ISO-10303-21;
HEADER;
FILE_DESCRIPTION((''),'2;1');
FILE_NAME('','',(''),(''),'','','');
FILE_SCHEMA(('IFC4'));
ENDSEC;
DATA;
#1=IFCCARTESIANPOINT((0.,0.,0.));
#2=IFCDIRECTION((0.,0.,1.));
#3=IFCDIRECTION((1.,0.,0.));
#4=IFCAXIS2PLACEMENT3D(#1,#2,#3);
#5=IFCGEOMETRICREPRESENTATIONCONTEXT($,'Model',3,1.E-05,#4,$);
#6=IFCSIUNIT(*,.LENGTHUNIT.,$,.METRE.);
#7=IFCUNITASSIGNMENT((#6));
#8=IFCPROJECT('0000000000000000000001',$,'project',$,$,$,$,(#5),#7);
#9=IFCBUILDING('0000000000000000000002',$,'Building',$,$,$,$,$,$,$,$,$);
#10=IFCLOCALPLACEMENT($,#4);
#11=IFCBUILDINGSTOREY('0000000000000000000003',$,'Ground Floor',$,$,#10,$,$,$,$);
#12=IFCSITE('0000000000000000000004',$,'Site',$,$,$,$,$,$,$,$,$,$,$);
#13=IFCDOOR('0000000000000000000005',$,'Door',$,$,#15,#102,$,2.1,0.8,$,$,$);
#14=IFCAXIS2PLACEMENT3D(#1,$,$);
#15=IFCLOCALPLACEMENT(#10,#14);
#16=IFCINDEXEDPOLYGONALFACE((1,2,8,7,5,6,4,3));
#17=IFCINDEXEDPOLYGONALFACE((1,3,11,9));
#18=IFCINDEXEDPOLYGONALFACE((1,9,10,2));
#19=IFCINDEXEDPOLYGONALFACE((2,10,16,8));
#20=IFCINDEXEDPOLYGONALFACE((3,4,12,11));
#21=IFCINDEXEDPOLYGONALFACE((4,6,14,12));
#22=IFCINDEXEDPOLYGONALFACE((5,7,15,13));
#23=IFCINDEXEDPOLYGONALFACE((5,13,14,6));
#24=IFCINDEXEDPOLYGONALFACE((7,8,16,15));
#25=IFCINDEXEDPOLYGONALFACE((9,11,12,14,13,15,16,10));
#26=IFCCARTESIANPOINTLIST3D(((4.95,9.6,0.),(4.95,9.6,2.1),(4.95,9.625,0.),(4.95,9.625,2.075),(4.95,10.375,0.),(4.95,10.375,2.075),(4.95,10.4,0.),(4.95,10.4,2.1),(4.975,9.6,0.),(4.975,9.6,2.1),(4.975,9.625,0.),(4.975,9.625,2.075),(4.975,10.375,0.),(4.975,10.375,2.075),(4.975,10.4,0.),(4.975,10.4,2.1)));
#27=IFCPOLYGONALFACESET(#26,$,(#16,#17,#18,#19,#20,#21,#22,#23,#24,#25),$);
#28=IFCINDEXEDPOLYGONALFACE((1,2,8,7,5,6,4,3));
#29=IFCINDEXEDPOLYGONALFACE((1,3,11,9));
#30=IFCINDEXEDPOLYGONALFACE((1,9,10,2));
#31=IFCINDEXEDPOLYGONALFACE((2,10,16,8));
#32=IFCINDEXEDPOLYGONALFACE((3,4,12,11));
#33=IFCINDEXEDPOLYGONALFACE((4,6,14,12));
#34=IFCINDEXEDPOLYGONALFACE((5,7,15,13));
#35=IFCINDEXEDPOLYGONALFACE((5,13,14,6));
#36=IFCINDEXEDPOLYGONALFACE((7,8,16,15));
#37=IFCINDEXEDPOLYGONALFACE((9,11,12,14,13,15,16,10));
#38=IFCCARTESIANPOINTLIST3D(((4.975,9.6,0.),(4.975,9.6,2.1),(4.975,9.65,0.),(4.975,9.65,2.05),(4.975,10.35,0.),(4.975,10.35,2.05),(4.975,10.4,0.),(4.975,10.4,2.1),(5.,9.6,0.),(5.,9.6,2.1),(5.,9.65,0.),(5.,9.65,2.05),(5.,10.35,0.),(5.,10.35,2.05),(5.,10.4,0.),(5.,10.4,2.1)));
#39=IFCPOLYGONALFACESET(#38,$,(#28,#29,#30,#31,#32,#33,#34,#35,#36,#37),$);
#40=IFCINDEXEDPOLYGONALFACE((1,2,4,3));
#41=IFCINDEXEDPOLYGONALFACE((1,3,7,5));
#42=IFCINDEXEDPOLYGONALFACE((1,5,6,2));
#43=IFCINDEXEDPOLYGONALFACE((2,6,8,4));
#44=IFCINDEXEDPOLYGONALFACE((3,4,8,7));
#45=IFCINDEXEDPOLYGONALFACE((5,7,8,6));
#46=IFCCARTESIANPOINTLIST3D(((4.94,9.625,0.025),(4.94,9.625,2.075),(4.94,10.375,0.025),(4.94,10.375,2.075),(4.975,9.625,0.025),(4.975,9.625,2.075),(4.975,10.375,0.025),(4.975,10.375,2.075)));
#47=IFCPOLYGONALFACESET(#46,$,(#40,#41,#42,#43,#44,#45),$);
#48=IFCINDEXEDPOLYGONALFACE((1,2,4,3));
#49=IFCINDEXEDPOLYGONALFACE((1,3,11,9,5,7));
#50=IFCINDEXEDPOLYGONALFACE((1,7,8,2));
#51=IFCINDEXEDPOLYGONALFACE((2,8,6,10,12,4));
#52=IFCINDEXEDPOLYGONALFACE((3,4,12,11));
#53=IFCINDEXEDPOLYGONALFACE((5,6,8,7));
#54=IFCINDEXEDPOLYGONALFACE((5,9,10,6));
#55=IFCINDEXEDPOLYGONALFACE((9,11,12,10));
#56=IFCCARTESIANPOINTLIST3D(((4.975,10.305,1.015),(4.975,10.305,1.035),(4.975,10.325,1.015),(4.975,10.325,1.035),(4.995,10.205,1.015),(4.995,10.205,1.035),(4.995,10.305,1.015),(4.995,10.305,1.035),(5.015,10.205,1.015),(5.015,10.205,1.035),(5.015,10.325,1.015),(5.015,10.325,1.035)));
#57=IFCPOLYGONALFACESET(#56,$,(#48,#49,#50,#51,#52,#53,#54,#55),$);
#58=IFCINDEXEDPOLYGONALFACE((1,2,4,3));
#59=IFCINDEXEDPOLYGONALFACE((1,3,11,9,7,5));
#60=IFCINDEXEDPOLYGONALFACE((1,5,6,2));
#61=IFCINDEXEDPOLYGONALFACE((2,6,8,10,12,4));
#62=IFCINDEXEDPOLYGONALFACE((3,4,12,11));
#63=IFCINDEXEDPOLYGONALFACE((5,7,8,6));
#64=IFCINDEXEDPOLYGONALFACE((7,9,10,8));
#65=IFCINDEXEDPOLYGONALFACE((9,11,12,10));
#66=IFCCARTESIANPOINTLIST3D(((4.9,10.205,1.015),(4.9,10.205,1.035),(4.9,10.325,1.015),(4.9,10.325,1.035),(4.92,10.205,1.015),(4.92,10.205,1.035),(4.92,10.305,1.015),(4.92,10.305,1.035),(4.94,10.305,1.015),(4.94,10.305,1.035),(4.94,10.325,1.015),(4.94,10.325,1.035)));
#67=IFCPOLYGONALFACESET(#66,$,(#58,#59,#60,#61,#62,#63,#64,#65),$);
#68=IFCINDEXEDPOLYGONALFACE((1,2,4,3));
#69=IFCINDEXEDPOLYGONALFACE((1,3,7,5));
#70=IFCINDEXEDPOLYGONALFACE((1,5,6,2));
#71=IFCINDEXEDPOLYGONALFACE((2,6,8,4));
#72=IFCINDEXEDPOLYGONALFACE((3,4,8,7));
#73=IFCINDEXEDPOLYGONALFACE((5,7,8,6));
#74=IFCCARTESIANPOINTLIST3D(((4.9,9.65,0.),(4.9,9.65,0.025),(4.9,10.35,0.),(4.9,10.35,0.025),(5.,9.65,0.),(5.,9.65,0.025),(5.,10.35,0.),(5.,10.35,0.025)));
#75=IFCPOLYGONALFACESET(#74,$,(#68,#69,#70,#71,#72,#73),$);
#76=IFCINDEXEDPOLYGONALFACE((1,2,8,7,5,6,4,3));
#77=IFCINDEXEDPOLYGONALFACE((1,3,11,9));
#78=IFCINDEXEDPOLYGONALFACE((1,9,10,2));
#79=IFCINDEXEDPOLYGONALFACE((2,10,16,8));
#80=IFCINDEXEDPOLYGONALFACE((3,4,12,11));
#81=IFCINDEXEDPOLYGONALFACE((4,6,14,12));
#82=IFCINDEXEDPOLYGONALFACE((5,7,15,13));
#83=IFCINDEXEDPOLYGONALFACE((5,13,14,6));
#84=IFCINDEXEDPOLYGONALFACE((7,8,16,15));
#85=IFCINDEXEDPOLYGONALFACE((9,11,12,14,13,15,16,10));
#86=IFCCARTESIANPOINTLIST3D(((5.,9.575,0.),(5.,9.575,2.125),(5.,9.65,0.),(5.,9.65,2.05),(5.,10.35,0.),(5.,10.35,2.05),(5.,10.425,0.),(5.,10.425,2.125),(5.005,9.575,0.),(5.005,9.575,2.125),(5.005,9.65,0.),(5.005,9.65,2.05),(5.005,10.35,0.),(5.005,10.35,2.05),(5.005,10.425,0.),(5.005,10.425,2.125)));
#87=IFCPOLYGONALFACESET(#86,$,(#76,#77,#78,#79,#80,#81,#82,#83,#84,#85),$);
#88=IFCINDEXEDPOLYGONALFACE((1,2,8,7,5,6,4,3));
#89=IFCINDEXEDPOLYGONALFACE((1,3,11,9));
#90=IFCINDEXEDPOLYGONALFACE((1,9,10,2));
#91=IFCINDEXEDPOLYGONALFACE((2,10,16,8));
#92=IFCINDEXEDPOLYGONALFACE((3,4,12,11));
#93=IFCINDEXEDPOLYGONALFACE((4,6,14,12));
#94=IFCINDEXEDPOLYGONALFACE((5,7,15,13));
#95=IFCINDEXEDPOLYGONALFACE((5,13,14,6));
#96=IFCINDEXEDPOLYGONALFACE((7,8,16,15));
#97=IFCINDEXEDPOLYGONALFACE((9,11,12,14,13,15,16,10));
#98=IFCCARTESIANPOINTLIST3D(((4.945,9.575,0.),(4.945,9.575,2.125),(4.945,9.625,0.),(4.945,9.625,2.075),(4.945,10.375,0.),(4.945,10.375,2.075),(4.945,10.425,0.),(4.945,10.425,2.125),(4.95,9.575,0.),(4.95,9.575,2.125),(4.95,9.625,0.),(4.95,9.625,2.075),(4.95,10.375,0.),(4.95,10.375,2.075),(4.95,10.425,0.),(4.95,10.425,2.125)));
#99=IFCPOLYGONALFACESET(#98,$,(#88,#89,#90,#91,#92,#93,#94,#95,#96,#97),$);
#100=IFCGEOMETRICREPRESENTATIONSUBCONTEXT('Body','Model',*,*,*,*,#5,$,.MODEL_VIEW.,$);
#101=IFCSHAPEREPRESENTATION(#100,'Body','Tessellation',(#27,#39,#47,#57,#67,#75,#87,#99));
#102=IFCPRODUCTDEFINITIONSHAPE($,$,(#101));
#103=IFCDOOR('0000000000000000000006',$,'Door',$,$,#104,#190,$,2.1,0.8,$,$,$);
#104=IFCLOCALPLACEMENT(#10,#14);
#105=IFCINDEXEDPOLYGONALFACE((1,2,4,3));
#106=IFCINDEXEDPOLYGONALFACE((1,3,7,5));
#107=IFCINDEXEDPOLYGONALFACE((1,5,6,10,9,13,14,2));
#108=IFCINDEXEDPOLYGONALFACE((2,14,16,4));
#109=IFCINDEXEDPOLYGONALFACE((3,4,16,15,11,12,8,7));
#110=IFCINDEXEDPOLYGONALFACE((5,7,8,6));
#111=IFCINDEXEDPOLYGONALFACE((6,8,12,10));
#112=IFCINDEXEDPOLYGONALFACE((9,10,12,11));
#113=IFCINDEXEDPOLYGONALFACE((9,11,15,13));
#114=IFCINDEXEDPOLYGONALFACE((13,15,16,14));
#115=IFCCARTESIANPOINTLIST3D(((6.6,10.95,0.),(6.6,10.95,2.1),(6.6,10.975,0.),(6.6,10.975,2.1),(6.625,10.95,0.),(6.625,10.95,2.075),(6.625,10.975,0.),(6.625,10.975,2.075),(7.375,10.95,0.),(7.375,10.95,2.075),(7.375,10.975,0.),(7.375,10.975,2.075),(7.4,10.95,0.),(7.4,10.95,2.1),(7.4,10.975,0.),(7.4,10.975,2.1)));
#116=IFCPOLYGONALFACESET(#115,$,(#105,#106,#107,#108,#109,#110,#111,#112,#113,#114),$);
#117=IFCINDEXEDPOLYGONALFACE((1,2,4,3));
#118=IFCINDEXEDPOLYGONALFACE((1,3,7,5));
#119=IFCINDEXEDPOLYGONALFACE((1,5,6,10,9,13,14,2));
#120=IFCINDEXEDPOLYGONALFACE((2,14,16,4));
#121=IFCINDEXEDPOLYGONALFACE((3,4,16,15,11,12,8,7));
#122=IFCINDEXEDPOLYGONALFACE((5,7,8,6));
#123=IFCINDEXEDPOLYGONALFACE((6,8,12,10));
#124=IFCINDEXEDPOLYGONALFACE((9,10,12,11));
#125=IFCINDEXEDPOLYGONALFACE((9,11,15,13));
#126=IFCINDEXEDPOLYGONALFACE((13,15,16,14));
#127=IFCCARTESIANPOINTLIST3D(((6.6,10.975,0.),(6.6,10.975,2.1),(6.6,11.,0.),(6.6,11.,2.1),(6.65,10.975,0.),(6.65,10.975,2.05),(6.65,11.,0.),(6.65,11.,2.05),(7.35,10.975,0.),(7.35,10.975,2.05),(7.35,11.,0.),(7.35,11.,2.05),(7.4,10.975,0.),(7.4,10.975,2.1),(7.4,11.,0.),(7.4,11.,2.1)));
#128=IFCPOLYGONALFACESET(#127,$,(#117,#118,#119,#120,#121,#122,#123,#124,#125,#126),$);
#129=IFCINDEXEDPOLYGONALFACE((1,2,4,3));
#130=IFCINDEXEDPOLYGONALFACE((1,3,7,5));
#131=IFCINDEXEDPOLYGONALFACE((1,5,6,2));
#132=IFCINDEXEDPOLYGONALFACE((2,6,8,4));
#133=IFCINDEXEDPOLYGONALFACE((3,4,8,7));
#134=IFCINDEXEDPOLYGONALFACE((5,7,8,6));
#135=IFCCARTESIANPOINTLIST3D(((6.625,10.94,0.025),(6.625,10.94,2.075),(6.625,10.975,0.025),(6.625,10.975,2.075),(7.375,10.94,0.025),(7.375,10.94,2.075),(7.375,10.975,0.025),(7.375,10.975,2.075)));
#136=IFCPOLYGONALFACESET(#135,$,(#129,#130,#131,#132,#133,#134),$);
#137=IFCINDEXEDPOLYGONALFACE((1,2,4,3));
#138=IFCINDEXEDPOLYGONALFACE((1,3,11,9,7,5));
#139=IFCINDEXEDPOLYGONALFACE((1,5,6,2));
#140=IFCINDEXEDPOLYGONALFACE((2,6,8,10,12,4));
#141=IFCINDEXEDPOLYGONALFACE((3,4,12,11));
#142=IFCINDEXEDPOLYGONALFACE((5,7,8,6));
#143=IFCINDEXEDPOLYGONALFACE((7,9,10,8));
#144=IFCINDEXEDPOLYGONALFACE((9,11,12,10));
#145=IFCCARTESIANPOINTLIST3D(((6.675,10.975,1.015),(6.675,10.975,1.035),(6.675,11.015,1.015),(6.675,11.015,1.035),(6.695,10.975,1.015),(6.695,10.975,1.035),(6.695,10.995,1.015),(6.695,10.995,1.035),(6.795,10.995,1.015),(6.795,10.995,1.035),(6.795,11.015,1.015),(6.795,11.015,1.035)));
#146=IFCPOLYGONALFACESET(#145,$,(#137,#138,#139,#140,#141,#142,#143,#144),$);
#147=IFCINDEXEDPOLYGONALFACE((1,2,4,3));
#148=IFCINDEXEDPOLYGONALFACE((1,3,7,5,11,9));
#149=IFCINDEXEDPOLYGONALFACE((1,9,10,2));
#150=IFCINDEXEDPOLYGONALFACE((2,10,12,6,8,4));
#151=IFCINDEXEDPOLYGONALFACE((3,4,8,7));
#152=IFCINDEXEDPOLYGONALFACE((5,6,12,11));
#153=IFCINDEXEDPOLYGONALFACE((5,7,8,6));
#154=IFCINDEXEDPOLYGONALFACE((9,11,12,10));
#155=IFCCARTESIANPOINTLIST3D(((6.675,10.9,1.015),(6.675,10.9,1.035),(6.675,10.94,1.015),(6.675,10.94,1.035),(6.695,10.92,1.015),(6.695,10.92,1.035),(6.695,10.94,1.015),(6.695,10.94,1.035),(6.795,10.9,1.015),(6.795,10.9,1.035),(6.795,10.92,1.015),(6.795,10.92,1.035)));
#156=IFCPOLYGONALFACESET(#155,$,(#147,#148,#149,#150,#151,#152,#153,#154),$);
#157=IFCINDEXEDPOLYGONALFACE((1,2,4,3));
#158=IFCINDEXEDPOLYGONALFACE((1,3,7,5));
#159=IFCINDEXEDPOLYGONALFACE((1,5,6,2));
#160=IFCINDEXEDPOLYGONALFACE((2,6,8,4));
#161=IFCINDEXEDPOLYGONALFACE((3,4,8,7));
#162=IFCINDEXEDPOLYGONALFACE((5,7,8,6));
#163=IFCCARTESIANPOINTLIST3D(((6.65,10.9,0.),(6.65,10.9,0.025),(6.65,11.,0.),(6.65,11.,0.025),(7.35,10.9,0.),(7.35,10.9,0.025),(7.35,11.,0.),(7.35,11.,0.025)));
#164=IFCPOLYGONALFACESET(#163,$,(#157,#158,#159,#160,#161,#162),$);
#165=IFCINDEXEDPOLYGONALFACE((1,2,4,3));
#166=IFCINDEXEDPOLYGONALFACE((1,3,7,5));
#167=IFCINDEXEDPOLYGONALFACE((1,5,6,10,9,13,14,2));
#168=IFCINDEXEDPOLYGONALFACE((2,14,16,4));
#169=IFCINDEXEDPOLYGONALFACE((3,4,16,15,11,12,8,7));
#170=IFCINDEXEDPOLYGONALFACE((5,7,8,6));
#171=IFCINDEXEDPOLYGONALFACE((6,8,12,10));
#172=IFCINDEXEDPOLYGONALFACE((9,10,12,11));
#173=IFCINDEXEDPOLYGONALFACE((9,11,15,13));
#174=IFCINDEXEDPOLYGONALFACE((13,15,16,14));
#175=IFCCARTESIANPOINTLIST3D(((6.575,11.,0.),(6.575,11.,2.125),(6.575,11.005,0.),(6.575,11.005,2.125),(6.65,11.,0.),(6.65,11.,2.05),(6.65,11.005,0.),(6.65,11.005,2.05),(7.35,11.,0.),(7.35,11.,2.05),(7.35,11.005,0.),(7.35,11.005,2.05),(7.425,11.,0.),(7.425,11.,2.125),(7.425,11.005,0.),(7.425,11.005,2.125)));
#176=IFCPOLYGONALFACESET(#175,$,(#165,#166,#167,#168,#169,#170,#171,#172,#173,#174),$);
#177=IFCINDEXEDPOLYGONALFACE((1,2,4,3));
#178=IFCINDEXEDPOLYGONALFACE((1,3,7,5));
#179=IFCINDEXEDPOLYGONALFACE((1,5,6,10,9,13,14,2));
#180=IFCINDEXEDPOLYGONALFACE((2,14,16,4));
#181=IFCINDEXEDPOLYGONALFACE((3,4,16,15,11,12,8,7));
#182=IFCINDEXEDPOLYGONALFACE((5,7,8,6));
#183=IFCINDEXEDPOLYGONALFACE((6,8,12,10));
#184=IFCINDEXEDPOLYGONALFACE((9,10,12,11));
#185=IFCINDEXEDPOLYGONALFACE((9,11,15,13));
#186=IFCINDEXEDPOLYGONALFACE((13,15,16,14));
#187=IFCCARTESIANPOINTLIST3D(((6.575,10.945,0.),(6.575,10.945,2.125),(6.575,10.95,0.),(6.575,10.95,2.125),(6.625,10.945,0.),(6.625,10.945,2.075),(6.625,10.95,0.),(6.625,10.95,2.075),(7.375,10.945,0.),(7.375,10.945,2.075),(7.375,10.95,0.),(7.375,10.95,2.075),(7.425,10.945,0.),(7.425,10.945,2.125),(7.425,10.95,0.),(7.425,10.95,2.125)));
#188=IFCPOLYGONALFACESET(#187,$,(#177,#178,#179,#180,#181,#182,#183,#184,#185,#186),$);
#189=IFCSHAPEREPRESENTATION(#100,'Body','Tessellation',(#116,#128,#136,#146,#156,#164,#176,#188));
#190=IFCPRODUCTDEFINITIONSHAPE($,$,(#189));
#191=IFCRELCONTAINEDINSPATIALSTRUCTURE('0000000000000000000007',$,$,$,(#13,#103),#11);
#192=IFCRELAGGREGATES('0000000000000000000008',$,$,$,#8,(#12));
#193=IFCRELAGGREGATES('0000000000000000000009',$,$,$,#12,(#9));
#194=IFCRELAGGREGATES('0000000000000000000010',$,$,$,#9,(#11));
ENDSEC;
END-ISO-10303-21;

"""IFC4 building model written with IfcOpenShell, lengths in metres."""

from ifc_helpers import new_model, si_unit, frame, origin_with_axes, place, context, subcontext, project, spatial, line, indexed_curve, outline, extrude, element, save


model = new_model("IFC4")

# Units and contexts
model_context = context("Model", 3, precision=1e-05, world=origin_with_axes())
body_context = subcontext(model_context, "Body", "Model", "MODEL_VIEW")
ifc_project = project(units=[si_unit("LENGTHUNIT", "METRE")], contexts=[model_context])

# Site, building, storey
site = spatial("IfcSite", under=ifc_project, Name="Site")
building = spatial("IfcBuilding", under=site, Name="Building")
storey_placement = place(None, origin_with_axes())
storey = spatial("IfcBuildingStorey", under=building, at=storey_placement, Name="Ground Floor")

# Doors
door_1_placement = place(storey_placement, frame((5.0, 9.6, 0.0), z_axis=(0.0, 0.0, 1.0), x_axis=(0.0, 1.0, 0.0)))
element("IfcDoor", 1, at=door_1_placement, inside=storey, Name="Door", OverallHeight=2.1, OverallWidth=0.8, context=body_context, shape_type="SweptSolid", body=[
    extrude(outline(indexed_curve([(0.0, 0.0), (0.0, 2.1), (0.8, 2.1), (0.8, 0.0), (0.775, 0.0), (0.775, 2.075), (0.025, 2.075), (0.025, 0.0)], segments=[line(1, 2, 3, 4, 5, 6, 7, 8, 1)])), frame((0.0, 0.025, 0.0), z_axis=(0.0, -1.0, 0.0), x_axis=(1.0, 0.0, 0.0)), (0.0, 0.0, -1.0), 0.025),
    extrude(outline(indexed_curve([(0.0, 0.0), (0.0, 2.1), (0.8, 2.1), (0.8, 0.0), (0.75, 0.0), (0.75, 2.05), (0.05, 2.05), (0.05, 0.0)], segments=[line(1, 2, 3, 4, 5, 6, 7, 8, 1)])), frame((0.0, 0.0, 0.0), z_axis=(0.0, -1.0, 0.0), x_axis=(1.0, 0.0, 0.0)), (0.0, 0.0, -1.0), 0.025),
    extrude(outline(indexed_curve([(0.0, 0.0), (0.75, 0.0), (0.75, 0.035), (0.0, 0.035)], segments=[line(1, 2, 3, 4, 1)])), frame((0.025, 0.025, 0.025), z_axis=(0.0, 0.0, 1.0), x_axis=(1.0, 0.0, 0.0)), (0.0, 0.0, 1.0), 2.05),
    extrude(outline(indexed_curve([(0.0, 0.0), (0.0, -0.04), (-0.12, -0.04), (-0.12, -0.02), (-0.02, -0.02), (-0.02, 0.0)], segments=[line(1, 2, 3, 4, 5, 6, 1)])), frame((0.725, 0.025, 1.015), z_axis=(0.0, 0.0, 1.0), x_axis=(1.0, 0.0, 0.0)), (0.0, 0.0, 1.0), 0.02),
    extrude(outline(indexed_curve([(0.0, 0.0), (0.0, 0.04), (-0.12, 0.04), (-0.12, 0.02), (-0.02, 0.02), (-0.02, 0.0)], segments=[line(1, 2, 3, 4, 5, 6, 1)])), frame((0.725, 0.06, 1.015), z_axis=(0.0, 0.0, 1.0), x_axis=(1.0, 0.0, 0.0)), (0.0, 0.0, 1.0), 0.02),
    extrude(outline(indexed_curve([(0.0, 0.0), (0.7, 0.0), (0.7, 0.1), (0.0, 0.1)], segments=[line(1, 2, 3, 4, 1)])), frame((0.05, 0.0, 0.0), z_axis=(0.0, 0.0, 1.0), x_axis=(1.0, 0.0, 0.0)), (0.0, 0.0, 1.0), 0.025),
    extrude(outline(indexed_curve([(0.0, 0.0), (0.0, 2.125), (0.85, 2.125), (0.85, 0.0), (0.775, 0.0), (0.775, 2.05), (0.075, 2.05), (0.075, 0.0)], segments=[line(1, 2, 3, 4, 5, 6, 7, 8, 1)])), frame((-0.025, -0.005, 0.0), z_axis=(0.0, -1.0, 0.0), x_axis=(1.0, 0.0, 0.0)), (0.0, 0.0, -1.0), 0.005),
    extrude(outline(indexed_curve([(0.0, 0.0), (0.0, 2.125), (0.85, 2.125), (0.85, 0.0), (0.8, 0.0), (0.8, 2.075), (0.05, 2.075), (0.05, 0.0)], segments=[line(1, 2, 3, 4, 5, 6, 7, 8, 1)])), frame((-0.025, 0.05, 0.0), z_axis=(0.0, -1.0, 0.0), x_axis=(1.0, 0.0, 0.0)), (0.0, 0.0, -1.0), 0.005),
])
door_2_placement = place(storey_placement, frame((7.4, 11.0, 0.0), z_axis=(0.0, 0.0, 1.0), x_axis=(-1.0, 0.0, 0.0)))
element("IfcDoor", 2, at=door_2_placement, inside=storey, Name="Door", OverallHeight=2.1, OverallWidth=0.8, context=body_context, shape_type="SweptSolid", body=[
    extrude(outline(indexed_curve([(0.0, 0.0), (0.0, 2.1), (0.8, 2.1), (0.8, 0.0), (0.775, 0.0), (0.775, 2.075), (0.025, 2.075), (0.025, 0.0)], segments=[line(1, 2, 3, 4, 5, 6, 7, 8, 1)])), frame((0.0, 0.025, 0.0), z_axis=(0.0, -1.0, 0.0), x_axis=(1.0, 0.0, 0.0)), (0.0, 0.0, -1.0), 0.025),
    extrude(outline(indexed_curve([(0.0, 0.0), (0.0, 2.1), (0.8, 2.1), (0.8, 0.0), (0.75, 0.0), (0.75, 2.05), (0.05, 2.05), (0.05, 0.0)], segments=[line(1, 2, 3, 4, 5, 6, 7, 8, 1)])), frame((0.0, 0.0, 0.0), z_axis=(0.0, -1.0, 0.0), x_axis=(1.0, 0.0, 0.0)), (0.0, 0.0, -1.0), 0.025),
    extrude(outline(indexed_curve([(0.0, 0.0), (0.75, 0.0), (0.75, 0.035), (0.0, 0.035)], segments=[line(1, 2, 3, 4, 1)])), frame((0.025, 0.025, 0.025), z_axis=(0.0, 0.0, 1.0), x_axis=(1.0, 0.0, 0.0)), (0.0, 0.0, 1.0), 2.05),
    extrude(outline(indexed_curve([(0.0, 0.0), (0.0, -0.04), (-0.12, -0.04), (-0.12, -0.02), (-0.02, -0.02), (-0.02, 0.0)], segments=[line(1, 2, 3, 4, 5, 6, 1)])), frame((0.725, 0.025, 1.015), z_axis=(0.0, 0.0, 1.0), x_axis=(1.0, 0.0, 0.0)), (0.0, 0.0, 1.0), 0.02),
    extrude(outline(indexed_curve([(0.0, 0.0), (0.0, 0.04), (-0.12, 0.04), (-0.12, 0.02), (-0.02, 0.02), (-0.02, 0.0)], segments=[line(1, 2, 3, 4, 5, 6, 1)])), frame((0.725, 0.06, 1.015), z_axis=(0.0, 0.0, 1.0), x_axis=(1.0, 0.0, 0.0)), (0.0, 0.0, 1.0), 0.02),
    extrude(outline(indexed_curve([(0.0, 0.0), (0.7, 0.0), (0.7, 0.1), (0.0, 0.1)], segments=[line(1, 2, 3, 4, 1)])), frame((0.05, 0.0, 0.0), z_axis=(0.0, 0.0, 1.0), x_axis=(1.0, 0.0, 0.0)), (0.0, 0.0, 1.0), 0.025),
    extrude(outline(indexed_curve([(0.0, 0.0), (0.0, 2.125), (0.85, 2.125), (0.85, 0.0), (0.775, 0.0), (0.775, 2.05), (0.075, 2.05), (0.075, 0.0)], segments=[line(1, 2, 3, 4, 5, 6, 7, 8, 1)])), frame((-0.025, -0.005, 0.0), z_axis=(0.0, -1.0, 0.0), x_axis=(1.0, 0.0, 0.0)), (0.0, 0.0, -1.0), 0.005),
    extrude(outline(indexed_curve([(0.0, 0.0), (0.0, 2.125), (0.85, 2.125), (0.85, 0.0), (0.8, 0.0), (0.8, 2.075), (0.05, 2.075), (0.05, 0.0)], segments=[line(1, 2, 3, 4, 5, 6, 7, 8, 1)])), frame((-0.025, 0.05, 0.0), z_axis=(0.0, -1.0, 0.0), x_axis=(1.0, 0.0, 0.0)), (0.0, 0.0, -1.0), 0.005),
])

save(model, "model.ifc")
